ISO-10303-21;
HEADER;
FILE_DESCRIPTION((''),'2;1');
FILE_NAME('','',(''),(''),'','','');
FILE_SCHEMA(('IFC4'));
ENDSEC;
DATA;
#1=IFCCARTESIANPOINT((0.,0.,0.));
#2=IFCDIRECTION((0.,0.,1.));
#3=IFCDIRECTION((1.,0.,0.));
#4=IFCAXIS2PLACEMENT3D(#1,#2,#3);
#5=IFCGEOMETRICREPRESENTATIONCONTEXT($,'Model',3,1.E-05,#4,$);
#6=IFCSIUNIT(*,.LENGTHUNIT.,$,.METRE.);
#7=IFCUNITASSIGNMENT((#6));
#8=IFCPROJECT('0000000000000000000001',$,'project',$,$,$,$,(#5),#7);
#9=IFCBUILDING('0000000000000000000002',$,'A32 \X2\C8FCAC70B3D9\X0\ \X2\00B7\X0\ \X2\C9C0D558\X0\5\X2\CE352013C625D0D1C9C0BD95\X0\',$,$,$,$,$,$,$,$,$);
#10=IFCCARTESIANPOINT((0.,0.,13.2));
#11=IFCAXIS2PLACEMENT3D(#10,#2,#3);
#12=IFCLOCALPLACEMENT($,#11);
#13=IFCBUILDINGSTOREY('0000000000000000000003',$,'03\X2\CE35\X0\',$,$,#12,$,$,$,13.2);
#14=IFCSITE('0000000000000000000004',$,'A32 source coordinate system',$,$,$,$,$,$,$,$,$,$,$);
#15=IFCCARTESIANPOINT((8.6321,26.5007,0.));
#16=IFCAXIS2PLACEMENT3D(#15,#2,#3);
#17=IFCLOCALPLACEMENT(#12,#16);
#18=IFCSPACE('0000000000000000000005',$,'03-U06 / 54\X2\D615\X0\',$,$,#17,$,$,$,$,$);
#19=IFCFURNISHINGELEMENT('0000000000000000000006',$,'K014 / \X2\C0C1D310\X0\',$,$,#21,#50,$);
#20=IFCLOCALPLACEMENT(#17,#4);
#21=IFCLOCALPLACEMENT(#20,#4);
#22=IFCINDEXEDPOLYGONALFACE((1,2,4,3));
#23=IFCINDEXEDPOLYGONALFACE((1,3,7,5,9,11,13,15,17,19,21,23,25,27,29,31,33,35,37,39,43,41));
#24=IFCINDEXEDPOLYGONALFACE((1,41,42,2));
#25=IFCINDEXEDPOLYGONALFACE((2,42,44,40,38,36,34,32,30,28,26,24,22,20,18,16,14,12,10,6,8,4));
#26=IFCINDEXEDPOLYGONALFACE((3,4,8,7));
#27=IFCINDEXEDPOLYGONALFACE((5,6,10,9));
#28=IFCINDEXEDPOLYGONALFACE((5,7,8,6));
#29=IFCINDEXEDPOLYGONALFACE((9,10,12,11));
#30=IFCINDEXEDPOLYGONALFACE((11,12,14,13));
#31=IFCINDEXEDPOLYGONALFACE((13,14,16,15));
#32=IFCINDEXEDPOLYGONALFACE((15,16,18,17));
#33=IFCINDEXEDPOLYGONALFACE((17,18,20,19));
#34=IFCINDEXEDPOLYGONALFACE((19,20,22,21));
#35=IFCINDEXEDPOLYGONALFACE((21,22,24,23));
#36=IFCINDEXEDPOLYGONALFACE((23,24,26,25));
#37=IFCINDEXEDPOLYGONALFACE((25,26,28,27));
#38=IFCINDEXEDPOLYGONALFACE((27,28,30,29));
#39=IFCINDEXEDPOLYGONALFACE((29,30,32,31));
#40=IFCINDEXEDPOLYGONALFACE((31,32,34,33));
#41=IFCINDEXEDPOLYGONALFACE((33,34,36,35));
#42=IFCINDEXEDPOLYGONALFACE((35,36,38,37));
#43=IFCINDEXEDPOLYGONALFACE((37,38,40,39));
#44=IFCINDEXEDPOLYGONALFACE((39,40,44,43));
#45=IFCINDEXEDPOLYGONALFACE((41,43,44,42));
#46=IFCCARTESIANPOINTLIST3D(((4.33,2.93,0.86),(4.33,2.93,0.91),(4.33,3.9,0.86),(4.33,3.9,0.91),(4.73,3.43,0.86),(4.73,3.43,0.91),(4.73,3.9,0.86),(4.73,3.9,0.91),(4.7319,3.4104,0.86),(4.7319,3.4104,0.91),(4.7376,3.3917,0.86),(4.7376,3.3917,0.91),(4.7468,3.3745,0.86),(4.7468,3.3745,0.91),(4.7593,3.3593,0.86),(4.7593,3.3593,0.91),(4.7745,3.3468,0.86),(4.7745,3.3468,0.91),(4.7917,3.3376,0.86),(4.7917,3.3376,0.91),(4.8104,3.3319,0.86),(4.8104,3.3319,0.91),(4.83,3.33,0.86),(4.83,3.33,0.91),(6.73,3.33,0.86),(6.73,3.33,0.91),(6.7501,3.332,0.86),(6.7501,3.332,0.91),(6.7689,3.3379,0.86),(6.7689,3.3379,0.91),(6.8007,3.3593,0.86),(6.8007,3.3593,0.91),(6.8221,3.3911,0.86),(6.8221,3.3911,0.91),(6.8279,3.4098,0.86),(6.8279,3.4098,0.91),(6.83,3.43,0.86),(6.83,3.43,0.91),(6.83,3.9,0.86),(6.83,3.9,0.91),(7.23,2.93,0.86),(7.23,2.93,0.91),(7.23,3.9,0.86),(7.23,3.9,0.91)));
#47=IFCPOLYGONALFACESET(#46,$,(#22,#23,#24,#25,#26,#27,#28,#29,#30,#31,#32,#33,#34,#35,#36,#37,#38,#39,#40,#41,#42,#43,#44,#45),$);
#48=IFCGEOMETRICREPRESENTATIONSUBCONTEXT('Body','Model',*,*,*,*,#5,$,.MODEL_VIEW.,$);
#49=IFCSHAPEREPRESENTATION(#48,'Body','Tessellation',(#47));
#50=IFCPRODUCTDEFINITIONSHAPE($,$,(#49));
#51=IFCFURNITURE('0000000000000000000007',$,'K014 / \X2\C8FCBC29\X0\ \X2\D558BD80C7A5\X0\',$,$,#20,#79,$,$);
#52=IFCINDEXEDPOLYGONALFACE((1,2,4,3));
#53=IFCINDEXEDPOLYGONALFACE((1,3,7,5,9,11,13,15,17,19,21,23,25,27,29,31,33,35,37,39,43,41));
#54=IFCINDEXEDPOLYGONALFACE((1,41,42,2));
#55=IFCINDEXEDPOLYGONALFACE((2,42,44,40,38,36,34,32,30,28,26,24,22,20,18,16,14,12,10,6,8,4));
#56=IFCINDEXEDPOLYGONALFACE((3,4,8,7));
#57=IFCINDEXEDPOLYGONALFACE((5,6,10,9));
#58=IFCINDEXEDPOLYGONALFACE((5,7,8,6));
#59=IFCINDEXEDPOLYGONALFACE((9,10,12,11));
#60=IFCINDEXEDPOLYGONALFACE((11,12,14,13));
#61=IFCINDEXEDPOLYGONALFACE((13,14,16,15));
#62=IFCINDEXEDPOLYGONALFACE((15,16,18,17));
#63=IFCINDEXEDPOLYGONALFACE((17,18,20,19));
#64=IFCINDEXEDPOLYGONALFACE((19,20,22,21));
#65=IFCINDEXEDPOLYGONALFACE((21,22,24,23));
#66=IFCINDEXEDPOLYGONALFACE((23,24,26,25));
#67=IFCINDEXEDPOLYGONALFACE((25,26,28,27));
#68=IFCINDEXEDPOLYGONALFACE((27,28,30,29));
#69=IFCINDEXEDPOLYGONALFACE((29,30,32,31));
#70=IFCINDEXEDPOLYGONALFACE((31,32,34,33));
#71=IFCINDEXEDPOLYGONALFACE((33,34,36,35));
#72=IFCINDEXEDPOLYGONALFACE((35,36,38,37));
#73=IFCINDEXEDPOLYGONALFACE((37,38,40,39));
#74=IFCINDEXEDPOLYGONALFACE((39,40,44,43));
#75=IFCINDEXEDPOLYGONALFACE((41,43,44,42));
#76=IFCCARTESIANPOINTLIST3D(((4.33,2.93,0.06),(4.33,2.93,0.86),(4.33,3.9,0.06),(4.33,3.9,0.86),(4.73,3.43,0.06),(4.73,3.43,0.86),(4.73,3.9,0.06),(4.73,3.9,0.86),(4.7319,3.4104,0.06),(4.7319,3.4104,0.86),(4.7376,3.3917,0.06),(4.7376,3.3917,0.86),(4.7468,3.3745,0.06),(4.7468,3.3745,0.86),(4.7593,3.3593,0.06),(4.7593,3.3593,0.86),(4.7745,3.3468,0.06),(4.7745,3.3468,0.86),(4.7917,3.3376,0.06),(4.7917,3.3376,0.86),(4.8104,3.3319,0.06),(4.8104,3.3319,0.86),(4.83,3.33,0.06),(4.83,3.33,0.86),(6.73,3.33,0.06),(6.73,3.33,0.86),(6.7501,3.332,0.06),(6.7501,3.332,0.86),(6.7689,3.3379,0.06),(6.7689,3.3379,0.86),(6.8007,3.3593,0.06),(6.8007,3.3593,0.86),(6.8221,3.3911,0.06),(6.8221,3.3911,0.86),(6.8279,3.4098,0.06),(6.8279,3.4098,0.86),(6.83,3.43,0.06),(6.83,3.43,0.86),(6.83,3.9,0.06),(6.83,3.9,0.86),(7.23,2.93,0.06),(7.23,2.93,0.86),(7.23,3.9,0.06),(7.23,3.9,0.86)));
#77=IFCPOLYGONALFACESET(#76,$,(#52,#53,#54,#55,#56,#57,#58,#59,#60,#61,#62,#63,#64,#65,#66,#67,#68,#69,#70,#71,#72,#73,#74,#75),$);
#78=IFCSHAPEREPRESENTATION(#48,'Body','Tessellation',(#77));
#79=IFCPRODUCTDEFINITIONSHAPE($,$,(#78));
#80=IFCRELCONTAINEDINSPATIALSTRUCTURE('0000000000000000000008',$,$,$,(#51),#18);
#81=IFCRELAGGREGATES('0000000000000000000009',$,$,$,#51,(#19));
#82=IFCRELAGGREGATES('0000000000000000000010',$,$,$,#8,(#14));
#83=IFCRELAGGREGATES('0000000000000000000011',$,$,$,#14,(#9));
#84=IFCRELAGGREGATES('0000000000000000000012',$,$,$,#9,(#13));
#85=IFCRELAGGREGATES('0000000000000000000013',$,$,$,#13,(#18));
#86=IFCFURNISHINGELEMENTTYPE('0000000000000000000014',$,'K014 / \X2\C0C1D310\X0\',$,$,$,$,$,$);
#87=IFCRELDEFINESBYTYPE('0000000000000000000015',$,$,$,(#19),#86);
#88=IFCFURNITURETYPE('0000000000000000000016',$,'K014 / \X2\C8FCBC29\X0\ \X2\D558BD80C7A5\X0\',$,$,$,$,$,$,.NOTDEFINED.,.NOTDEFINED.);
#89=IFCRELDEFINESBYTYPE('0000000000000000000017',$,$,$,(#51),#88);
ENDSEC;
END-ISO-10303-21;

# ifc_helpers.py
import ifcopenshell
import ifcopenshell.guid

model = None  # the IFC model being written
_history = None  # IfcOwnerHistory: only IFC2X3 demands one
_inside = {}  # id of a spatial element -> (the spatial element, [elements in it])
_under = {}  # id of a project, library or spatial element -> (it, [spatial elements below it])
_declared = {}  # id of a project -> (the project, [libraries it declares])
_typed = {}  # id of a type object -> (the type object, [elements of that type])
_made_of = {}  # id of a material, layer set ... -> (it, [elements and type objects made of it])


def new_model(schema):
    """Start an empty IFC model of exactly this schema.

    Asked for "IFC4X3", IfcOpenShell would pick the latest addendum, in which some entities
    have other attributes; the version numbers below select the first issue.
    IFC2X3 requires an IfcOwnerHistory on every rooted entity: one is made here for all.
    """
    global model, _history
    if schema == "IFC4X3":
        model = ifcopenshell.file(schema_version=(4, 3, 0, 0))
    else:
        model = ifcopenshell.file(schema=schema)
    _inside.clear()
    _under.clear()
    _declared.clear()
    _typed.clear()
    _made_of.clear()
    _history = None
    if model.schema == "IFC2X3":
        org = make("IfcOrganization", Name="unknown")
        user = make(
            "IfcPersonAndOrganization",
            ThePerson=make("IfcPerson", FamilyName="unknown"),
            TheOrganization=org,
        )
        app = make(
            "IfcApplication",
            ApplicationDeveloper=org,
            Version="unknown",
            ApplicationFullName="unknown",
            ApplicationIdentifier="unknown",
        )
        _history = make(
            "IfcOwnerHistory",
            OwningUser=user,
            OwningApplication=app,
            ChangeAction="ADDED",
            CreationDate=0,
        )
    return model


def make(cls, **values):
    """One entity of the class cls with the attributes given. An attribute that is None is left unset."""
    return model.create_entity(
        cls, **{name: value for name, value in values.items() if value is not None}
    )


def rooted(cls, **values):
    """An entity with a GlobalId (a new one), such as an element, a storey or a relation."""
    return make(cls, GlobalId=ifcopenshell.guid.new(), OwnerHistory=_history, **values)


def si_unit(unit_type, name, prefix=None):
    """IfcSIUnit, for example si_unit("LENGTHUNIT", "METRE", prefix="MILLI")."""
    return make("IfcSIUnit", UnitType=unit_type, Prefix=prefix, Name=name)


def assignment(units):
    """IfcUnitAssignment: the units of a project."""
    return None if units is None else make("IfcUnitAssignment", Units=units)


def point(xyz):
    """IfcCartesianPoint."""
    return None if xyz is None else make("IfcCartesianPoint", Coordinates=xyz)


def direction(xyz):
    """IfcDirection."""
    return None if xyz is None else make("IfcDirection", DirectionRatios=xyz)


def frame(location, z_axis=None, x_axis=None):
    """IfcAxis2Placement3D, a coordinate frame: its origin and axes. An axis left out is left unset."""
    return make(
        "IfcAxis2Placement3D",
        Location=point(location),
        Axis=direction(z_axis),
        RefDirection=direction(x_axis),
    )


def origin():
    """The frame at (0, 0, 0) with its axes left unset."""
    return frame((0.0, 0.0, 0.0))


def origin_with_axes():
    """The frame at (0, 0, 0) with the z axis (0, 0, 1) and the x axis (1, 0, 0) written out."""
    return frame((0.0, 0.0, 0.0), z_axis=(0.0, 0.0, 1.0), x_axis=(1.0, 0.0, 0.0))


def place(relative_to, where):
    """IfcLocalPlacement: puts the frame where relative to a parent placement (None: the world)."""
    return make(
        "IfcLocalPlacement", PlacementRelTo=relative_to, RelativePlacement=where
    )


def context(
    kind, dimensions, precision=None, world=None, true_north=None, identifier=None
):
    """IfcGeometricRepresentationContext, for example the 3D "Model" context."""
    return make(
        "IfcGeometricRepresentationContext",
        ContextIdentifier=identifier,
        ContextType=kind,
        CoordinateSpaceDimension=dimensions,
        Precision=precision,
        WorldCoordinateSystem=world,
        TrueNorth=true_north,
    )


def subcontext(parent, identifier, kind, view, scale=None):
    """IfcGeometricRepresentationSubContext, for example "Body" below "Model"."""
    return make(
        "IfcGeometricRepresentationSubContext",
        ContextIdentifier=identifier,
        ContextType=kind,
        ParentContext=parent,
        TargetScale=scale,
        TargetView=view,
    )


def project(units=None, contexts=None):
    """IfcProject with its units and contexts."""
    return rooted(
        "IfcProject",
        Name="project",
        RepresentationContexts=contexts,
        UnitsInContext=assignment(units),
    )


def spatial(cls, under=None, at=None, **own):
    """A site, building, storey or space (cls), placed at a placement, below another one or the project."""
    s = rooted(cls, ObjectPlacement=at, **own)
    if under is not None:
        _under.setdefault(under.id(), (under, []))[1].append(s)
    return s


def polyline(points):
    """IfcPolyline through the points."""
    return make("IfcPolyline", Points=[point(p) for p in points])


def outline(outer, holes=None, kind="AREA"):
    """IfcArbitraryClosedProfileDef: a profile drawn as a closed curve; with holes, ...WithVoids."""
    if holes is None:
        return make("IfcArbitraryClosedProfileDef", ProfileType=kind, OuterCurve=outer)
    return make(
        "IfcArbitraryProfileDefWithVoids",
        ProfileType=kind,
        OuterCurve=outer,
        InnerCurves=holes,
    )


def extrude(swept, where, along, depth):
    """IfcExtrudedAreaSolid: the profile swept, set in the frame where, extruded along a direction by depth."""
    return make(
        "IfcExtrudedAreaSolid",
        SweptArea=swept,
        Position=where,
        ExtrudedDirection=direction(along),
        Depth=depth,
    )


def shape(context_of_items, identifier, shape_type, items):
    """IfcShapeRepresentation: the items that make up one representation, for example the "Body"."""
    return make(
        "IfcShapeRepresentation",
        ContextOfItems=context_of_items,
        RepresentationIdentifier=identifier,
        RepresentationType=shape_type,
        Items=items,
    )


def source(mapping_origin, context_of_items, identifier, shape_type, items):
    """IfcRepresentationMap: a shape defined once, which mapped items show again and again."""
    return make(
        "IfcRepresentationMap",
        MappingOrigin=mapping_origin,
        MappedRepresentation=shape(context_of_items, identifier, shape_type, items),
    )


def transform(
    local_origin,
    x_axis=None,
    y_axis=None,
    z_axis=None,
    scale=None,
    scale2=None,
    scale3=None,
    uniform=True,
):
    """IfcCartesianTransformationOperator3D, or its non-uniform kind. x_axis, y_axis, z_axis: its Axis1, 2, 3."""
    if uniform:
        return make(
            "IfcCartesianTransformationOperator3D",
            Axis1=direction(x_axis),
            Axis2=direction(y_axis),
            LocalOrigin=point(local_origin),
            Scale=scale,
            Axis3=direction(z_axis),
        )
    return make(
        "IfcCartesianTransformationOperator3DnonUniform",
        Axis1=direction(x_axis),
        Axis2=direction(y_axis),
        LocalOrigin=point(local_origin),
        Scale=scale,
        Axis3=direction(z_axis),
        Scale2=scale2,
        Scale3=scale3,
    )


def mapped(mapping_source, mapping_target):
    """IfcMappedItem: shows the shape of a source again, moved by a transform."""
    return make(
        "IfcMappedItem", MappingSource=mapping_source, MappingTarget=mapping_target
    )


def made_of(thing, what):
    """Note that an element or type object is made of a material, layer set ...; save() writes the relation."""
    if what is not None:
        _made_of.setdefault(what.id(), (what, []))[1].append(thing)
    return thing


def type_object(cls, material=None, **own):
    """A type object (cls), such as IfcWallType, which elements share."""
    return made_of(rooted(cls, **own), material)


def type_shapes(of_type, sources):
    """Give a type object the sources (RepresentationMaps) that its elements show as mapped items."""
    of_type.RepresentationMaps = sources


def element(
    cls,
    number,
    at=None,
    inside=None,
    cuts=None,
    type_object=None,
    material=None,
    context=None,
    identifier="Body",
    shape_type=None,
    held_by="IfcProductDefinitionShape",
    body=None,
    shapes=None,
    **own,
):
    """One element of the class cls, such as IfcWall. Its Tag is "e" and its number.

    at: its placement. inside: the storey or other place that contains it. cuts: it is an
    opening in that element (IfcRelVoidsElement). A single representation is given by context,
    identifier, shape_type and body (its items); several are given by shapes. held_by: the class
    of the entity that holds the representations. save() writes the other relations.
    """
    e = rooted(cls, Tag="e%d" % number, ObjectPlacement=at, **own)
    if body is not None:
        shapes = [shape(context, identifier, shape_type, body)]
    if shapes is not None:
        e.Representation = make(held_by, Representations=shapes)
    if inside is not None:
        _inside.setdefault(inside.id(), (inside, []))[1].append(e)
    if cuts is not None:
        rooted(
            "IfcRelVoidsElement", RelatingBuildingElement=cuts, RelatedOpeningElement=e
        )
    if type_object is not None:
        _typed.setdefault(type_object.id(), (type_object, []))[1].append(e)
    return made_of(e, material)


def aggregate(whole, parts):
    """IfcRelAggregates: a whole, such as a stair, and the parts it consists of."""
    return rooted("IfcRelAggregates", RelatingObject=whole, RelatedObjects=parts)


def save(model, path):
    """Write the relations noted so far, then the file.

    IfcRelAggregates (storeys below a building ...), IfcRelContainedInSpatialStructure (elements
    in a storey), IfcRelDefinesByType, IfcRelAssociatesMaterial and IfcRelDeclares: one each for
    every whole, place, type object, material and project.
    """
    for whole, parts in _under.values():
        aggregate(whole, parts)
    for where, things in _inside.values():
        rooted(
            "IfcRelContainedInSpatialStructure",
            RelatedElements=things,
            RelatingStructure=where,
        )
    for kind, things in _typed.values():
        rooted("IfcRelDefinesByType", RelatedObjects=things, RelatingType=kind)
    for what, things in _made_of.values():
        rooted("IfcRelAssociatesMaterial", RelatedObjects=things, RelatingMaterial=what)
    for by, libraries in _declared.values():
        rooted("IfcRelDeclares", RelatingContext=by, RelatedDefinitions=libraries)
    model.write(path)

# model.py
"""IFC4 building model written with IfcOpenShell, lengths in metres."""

from ifc_helpers import new_model, si_unit, frame, origin, origin_with_axes, place, context, subcontext, project, spatial, polyline, outline, extrude, source, transform, mapped, type_object, type_shapes, element, aggregate, save


model = new_model("IFC4")

# Units and contexts
model_context = context("Model", 3, precision=1e-05, world=origin_with_axes())
body_context = subcontext(model_context, "Body", "Model", "MODEL_VIEW")
ifc_project = project(units=[si_unit("LENGTHUNIT", "METRE")], contexts=[model_context])

# Site, building, storey, space
site = spatial("IfcSite", under=ifc_project, Name="A32 source coordinate system")
building = spatial("IfcBuilding", under=site, Name="A32 주거동 · 지하5층–옥탑지붕")
storey_placement = place(None, frame((0.0, 0.0, 13.2), z_axis=(0.0, 0.0, 1.0), x_axis=(1.0, 0.0, 0.0)))
storey = spatial("IfcBuildingStorey", under=building, at=storey_placement, Name="03층", Elevation=13.2)
space_placement = place(storey_placement, frame((8.6321, 26.5007, 0.0), z_axis=(0.0, 0.0, 1.0), x_axis=(1.0, 0.0, 0.0)))
space = spatial("IfcSpace", under=storey, at=space_placement, Name="03-U06 / 54형")

# Furnishing element
furnishing_element_type_1 = type_object("IfcFurnishingElementType", Name="K014 / 상판")
shared_shape_1 = source(origin(), body_context, "Body", "SweptSolid", [
    extrude(outline(polyline([(4.33, 2.93), (4.33, 3.9), (4.73, 3.9), (4.73, 3.43), (4.7319, 3.4104), (4.7376, 3.3917), (4.7468, 3.3745), (4.7593, 3.3593), (4.7745, 3.3468), (4.7917, 3.3376), (4.8104, 3.3319), (4.83, 3.33), (6.73, 3.33), (6.7501, 3.332), (6.7689, 3.3379), (6.8007, 3.3593), (6.8221, 3.3911), (6.8279, 3.4098), (6.83, 3.43), (6.83, 3.9), (7.23, 3.9), (7.23, 2.93), (4.33, 2.93)])), frame((0.0, 0.0, 0.86)), (0.0, 0.0, 1.0), 0.05),
])
type_shapes(furnishing_element_type_1, [shared_shape_1])
furniture_1_placement = place(space_placement, origin_with_axes())
furnishing_1_placement = place(furniture_1_placement, origin_with_axes())
furnishing_1 = element("IfcFurnishingElement", 1, at=furnishing_1_placement, type_object=furnishing_element_type_1, Name="K014 / 상판", context=body_context, shape_type="MappedRepresentation", body=[
    mapped(shared_shape_1, transform((0.0, 0.0, 0.0), scale=1.0)),
])

# Furniture
furniture_type_1 = type_object("IfcFurnitureType", Name="K014 / 주방 하부장", AssemblyPlace="NOTDEFINED", PredefinedType="NOTDEFINED")
shared_shape_2 = source(origin(), body_context, "Body", "SweptSolid", [
    extrude(outline(polyline([(7.23, 2.93), (4.33, 2.93), (4.33, 3.9), (4.73, 3.9), (4.73, 3.43), (4.7319, 3.4104), (4.7376, 3.3917), (4.7468, 3.3745), (4.7593, 3.3593), (4.7745, 3.3468), (4.7917, 3.3376), (4.8104, 3.3319), (4.83, 3.33), (6.73, 3.33), (6.7501, 3.332), (6.7689, 3.3379), (6.8007, 3.3593), (6.8221, 3.3911), (6.8279, 3.4098), (6.83, 3.43), (6.83, 3.9), (7.23, 3.9), (7.23, 2.93)])), frame((0.0, 0.0, 0.06)), (0.0, 0.0, 1.0), 0.8),
])
type_shapes(furniture_type_1, [shared_shape_2])
furniture_1 = element("IfcFurniture", 2, at=furniture_1_placement, inside=space, type_object=furniture_type_1, Name="K014 / 주방 하부장", context=body_context, shape_type="MappedRepresentation", body=[
    mapped(shared_shape_2, transform((0.0, 0.0, 0.0), scale=1.0)),
])
aggregate(furniture_1, [furnishing_1])

save(model, "model.ifc")
